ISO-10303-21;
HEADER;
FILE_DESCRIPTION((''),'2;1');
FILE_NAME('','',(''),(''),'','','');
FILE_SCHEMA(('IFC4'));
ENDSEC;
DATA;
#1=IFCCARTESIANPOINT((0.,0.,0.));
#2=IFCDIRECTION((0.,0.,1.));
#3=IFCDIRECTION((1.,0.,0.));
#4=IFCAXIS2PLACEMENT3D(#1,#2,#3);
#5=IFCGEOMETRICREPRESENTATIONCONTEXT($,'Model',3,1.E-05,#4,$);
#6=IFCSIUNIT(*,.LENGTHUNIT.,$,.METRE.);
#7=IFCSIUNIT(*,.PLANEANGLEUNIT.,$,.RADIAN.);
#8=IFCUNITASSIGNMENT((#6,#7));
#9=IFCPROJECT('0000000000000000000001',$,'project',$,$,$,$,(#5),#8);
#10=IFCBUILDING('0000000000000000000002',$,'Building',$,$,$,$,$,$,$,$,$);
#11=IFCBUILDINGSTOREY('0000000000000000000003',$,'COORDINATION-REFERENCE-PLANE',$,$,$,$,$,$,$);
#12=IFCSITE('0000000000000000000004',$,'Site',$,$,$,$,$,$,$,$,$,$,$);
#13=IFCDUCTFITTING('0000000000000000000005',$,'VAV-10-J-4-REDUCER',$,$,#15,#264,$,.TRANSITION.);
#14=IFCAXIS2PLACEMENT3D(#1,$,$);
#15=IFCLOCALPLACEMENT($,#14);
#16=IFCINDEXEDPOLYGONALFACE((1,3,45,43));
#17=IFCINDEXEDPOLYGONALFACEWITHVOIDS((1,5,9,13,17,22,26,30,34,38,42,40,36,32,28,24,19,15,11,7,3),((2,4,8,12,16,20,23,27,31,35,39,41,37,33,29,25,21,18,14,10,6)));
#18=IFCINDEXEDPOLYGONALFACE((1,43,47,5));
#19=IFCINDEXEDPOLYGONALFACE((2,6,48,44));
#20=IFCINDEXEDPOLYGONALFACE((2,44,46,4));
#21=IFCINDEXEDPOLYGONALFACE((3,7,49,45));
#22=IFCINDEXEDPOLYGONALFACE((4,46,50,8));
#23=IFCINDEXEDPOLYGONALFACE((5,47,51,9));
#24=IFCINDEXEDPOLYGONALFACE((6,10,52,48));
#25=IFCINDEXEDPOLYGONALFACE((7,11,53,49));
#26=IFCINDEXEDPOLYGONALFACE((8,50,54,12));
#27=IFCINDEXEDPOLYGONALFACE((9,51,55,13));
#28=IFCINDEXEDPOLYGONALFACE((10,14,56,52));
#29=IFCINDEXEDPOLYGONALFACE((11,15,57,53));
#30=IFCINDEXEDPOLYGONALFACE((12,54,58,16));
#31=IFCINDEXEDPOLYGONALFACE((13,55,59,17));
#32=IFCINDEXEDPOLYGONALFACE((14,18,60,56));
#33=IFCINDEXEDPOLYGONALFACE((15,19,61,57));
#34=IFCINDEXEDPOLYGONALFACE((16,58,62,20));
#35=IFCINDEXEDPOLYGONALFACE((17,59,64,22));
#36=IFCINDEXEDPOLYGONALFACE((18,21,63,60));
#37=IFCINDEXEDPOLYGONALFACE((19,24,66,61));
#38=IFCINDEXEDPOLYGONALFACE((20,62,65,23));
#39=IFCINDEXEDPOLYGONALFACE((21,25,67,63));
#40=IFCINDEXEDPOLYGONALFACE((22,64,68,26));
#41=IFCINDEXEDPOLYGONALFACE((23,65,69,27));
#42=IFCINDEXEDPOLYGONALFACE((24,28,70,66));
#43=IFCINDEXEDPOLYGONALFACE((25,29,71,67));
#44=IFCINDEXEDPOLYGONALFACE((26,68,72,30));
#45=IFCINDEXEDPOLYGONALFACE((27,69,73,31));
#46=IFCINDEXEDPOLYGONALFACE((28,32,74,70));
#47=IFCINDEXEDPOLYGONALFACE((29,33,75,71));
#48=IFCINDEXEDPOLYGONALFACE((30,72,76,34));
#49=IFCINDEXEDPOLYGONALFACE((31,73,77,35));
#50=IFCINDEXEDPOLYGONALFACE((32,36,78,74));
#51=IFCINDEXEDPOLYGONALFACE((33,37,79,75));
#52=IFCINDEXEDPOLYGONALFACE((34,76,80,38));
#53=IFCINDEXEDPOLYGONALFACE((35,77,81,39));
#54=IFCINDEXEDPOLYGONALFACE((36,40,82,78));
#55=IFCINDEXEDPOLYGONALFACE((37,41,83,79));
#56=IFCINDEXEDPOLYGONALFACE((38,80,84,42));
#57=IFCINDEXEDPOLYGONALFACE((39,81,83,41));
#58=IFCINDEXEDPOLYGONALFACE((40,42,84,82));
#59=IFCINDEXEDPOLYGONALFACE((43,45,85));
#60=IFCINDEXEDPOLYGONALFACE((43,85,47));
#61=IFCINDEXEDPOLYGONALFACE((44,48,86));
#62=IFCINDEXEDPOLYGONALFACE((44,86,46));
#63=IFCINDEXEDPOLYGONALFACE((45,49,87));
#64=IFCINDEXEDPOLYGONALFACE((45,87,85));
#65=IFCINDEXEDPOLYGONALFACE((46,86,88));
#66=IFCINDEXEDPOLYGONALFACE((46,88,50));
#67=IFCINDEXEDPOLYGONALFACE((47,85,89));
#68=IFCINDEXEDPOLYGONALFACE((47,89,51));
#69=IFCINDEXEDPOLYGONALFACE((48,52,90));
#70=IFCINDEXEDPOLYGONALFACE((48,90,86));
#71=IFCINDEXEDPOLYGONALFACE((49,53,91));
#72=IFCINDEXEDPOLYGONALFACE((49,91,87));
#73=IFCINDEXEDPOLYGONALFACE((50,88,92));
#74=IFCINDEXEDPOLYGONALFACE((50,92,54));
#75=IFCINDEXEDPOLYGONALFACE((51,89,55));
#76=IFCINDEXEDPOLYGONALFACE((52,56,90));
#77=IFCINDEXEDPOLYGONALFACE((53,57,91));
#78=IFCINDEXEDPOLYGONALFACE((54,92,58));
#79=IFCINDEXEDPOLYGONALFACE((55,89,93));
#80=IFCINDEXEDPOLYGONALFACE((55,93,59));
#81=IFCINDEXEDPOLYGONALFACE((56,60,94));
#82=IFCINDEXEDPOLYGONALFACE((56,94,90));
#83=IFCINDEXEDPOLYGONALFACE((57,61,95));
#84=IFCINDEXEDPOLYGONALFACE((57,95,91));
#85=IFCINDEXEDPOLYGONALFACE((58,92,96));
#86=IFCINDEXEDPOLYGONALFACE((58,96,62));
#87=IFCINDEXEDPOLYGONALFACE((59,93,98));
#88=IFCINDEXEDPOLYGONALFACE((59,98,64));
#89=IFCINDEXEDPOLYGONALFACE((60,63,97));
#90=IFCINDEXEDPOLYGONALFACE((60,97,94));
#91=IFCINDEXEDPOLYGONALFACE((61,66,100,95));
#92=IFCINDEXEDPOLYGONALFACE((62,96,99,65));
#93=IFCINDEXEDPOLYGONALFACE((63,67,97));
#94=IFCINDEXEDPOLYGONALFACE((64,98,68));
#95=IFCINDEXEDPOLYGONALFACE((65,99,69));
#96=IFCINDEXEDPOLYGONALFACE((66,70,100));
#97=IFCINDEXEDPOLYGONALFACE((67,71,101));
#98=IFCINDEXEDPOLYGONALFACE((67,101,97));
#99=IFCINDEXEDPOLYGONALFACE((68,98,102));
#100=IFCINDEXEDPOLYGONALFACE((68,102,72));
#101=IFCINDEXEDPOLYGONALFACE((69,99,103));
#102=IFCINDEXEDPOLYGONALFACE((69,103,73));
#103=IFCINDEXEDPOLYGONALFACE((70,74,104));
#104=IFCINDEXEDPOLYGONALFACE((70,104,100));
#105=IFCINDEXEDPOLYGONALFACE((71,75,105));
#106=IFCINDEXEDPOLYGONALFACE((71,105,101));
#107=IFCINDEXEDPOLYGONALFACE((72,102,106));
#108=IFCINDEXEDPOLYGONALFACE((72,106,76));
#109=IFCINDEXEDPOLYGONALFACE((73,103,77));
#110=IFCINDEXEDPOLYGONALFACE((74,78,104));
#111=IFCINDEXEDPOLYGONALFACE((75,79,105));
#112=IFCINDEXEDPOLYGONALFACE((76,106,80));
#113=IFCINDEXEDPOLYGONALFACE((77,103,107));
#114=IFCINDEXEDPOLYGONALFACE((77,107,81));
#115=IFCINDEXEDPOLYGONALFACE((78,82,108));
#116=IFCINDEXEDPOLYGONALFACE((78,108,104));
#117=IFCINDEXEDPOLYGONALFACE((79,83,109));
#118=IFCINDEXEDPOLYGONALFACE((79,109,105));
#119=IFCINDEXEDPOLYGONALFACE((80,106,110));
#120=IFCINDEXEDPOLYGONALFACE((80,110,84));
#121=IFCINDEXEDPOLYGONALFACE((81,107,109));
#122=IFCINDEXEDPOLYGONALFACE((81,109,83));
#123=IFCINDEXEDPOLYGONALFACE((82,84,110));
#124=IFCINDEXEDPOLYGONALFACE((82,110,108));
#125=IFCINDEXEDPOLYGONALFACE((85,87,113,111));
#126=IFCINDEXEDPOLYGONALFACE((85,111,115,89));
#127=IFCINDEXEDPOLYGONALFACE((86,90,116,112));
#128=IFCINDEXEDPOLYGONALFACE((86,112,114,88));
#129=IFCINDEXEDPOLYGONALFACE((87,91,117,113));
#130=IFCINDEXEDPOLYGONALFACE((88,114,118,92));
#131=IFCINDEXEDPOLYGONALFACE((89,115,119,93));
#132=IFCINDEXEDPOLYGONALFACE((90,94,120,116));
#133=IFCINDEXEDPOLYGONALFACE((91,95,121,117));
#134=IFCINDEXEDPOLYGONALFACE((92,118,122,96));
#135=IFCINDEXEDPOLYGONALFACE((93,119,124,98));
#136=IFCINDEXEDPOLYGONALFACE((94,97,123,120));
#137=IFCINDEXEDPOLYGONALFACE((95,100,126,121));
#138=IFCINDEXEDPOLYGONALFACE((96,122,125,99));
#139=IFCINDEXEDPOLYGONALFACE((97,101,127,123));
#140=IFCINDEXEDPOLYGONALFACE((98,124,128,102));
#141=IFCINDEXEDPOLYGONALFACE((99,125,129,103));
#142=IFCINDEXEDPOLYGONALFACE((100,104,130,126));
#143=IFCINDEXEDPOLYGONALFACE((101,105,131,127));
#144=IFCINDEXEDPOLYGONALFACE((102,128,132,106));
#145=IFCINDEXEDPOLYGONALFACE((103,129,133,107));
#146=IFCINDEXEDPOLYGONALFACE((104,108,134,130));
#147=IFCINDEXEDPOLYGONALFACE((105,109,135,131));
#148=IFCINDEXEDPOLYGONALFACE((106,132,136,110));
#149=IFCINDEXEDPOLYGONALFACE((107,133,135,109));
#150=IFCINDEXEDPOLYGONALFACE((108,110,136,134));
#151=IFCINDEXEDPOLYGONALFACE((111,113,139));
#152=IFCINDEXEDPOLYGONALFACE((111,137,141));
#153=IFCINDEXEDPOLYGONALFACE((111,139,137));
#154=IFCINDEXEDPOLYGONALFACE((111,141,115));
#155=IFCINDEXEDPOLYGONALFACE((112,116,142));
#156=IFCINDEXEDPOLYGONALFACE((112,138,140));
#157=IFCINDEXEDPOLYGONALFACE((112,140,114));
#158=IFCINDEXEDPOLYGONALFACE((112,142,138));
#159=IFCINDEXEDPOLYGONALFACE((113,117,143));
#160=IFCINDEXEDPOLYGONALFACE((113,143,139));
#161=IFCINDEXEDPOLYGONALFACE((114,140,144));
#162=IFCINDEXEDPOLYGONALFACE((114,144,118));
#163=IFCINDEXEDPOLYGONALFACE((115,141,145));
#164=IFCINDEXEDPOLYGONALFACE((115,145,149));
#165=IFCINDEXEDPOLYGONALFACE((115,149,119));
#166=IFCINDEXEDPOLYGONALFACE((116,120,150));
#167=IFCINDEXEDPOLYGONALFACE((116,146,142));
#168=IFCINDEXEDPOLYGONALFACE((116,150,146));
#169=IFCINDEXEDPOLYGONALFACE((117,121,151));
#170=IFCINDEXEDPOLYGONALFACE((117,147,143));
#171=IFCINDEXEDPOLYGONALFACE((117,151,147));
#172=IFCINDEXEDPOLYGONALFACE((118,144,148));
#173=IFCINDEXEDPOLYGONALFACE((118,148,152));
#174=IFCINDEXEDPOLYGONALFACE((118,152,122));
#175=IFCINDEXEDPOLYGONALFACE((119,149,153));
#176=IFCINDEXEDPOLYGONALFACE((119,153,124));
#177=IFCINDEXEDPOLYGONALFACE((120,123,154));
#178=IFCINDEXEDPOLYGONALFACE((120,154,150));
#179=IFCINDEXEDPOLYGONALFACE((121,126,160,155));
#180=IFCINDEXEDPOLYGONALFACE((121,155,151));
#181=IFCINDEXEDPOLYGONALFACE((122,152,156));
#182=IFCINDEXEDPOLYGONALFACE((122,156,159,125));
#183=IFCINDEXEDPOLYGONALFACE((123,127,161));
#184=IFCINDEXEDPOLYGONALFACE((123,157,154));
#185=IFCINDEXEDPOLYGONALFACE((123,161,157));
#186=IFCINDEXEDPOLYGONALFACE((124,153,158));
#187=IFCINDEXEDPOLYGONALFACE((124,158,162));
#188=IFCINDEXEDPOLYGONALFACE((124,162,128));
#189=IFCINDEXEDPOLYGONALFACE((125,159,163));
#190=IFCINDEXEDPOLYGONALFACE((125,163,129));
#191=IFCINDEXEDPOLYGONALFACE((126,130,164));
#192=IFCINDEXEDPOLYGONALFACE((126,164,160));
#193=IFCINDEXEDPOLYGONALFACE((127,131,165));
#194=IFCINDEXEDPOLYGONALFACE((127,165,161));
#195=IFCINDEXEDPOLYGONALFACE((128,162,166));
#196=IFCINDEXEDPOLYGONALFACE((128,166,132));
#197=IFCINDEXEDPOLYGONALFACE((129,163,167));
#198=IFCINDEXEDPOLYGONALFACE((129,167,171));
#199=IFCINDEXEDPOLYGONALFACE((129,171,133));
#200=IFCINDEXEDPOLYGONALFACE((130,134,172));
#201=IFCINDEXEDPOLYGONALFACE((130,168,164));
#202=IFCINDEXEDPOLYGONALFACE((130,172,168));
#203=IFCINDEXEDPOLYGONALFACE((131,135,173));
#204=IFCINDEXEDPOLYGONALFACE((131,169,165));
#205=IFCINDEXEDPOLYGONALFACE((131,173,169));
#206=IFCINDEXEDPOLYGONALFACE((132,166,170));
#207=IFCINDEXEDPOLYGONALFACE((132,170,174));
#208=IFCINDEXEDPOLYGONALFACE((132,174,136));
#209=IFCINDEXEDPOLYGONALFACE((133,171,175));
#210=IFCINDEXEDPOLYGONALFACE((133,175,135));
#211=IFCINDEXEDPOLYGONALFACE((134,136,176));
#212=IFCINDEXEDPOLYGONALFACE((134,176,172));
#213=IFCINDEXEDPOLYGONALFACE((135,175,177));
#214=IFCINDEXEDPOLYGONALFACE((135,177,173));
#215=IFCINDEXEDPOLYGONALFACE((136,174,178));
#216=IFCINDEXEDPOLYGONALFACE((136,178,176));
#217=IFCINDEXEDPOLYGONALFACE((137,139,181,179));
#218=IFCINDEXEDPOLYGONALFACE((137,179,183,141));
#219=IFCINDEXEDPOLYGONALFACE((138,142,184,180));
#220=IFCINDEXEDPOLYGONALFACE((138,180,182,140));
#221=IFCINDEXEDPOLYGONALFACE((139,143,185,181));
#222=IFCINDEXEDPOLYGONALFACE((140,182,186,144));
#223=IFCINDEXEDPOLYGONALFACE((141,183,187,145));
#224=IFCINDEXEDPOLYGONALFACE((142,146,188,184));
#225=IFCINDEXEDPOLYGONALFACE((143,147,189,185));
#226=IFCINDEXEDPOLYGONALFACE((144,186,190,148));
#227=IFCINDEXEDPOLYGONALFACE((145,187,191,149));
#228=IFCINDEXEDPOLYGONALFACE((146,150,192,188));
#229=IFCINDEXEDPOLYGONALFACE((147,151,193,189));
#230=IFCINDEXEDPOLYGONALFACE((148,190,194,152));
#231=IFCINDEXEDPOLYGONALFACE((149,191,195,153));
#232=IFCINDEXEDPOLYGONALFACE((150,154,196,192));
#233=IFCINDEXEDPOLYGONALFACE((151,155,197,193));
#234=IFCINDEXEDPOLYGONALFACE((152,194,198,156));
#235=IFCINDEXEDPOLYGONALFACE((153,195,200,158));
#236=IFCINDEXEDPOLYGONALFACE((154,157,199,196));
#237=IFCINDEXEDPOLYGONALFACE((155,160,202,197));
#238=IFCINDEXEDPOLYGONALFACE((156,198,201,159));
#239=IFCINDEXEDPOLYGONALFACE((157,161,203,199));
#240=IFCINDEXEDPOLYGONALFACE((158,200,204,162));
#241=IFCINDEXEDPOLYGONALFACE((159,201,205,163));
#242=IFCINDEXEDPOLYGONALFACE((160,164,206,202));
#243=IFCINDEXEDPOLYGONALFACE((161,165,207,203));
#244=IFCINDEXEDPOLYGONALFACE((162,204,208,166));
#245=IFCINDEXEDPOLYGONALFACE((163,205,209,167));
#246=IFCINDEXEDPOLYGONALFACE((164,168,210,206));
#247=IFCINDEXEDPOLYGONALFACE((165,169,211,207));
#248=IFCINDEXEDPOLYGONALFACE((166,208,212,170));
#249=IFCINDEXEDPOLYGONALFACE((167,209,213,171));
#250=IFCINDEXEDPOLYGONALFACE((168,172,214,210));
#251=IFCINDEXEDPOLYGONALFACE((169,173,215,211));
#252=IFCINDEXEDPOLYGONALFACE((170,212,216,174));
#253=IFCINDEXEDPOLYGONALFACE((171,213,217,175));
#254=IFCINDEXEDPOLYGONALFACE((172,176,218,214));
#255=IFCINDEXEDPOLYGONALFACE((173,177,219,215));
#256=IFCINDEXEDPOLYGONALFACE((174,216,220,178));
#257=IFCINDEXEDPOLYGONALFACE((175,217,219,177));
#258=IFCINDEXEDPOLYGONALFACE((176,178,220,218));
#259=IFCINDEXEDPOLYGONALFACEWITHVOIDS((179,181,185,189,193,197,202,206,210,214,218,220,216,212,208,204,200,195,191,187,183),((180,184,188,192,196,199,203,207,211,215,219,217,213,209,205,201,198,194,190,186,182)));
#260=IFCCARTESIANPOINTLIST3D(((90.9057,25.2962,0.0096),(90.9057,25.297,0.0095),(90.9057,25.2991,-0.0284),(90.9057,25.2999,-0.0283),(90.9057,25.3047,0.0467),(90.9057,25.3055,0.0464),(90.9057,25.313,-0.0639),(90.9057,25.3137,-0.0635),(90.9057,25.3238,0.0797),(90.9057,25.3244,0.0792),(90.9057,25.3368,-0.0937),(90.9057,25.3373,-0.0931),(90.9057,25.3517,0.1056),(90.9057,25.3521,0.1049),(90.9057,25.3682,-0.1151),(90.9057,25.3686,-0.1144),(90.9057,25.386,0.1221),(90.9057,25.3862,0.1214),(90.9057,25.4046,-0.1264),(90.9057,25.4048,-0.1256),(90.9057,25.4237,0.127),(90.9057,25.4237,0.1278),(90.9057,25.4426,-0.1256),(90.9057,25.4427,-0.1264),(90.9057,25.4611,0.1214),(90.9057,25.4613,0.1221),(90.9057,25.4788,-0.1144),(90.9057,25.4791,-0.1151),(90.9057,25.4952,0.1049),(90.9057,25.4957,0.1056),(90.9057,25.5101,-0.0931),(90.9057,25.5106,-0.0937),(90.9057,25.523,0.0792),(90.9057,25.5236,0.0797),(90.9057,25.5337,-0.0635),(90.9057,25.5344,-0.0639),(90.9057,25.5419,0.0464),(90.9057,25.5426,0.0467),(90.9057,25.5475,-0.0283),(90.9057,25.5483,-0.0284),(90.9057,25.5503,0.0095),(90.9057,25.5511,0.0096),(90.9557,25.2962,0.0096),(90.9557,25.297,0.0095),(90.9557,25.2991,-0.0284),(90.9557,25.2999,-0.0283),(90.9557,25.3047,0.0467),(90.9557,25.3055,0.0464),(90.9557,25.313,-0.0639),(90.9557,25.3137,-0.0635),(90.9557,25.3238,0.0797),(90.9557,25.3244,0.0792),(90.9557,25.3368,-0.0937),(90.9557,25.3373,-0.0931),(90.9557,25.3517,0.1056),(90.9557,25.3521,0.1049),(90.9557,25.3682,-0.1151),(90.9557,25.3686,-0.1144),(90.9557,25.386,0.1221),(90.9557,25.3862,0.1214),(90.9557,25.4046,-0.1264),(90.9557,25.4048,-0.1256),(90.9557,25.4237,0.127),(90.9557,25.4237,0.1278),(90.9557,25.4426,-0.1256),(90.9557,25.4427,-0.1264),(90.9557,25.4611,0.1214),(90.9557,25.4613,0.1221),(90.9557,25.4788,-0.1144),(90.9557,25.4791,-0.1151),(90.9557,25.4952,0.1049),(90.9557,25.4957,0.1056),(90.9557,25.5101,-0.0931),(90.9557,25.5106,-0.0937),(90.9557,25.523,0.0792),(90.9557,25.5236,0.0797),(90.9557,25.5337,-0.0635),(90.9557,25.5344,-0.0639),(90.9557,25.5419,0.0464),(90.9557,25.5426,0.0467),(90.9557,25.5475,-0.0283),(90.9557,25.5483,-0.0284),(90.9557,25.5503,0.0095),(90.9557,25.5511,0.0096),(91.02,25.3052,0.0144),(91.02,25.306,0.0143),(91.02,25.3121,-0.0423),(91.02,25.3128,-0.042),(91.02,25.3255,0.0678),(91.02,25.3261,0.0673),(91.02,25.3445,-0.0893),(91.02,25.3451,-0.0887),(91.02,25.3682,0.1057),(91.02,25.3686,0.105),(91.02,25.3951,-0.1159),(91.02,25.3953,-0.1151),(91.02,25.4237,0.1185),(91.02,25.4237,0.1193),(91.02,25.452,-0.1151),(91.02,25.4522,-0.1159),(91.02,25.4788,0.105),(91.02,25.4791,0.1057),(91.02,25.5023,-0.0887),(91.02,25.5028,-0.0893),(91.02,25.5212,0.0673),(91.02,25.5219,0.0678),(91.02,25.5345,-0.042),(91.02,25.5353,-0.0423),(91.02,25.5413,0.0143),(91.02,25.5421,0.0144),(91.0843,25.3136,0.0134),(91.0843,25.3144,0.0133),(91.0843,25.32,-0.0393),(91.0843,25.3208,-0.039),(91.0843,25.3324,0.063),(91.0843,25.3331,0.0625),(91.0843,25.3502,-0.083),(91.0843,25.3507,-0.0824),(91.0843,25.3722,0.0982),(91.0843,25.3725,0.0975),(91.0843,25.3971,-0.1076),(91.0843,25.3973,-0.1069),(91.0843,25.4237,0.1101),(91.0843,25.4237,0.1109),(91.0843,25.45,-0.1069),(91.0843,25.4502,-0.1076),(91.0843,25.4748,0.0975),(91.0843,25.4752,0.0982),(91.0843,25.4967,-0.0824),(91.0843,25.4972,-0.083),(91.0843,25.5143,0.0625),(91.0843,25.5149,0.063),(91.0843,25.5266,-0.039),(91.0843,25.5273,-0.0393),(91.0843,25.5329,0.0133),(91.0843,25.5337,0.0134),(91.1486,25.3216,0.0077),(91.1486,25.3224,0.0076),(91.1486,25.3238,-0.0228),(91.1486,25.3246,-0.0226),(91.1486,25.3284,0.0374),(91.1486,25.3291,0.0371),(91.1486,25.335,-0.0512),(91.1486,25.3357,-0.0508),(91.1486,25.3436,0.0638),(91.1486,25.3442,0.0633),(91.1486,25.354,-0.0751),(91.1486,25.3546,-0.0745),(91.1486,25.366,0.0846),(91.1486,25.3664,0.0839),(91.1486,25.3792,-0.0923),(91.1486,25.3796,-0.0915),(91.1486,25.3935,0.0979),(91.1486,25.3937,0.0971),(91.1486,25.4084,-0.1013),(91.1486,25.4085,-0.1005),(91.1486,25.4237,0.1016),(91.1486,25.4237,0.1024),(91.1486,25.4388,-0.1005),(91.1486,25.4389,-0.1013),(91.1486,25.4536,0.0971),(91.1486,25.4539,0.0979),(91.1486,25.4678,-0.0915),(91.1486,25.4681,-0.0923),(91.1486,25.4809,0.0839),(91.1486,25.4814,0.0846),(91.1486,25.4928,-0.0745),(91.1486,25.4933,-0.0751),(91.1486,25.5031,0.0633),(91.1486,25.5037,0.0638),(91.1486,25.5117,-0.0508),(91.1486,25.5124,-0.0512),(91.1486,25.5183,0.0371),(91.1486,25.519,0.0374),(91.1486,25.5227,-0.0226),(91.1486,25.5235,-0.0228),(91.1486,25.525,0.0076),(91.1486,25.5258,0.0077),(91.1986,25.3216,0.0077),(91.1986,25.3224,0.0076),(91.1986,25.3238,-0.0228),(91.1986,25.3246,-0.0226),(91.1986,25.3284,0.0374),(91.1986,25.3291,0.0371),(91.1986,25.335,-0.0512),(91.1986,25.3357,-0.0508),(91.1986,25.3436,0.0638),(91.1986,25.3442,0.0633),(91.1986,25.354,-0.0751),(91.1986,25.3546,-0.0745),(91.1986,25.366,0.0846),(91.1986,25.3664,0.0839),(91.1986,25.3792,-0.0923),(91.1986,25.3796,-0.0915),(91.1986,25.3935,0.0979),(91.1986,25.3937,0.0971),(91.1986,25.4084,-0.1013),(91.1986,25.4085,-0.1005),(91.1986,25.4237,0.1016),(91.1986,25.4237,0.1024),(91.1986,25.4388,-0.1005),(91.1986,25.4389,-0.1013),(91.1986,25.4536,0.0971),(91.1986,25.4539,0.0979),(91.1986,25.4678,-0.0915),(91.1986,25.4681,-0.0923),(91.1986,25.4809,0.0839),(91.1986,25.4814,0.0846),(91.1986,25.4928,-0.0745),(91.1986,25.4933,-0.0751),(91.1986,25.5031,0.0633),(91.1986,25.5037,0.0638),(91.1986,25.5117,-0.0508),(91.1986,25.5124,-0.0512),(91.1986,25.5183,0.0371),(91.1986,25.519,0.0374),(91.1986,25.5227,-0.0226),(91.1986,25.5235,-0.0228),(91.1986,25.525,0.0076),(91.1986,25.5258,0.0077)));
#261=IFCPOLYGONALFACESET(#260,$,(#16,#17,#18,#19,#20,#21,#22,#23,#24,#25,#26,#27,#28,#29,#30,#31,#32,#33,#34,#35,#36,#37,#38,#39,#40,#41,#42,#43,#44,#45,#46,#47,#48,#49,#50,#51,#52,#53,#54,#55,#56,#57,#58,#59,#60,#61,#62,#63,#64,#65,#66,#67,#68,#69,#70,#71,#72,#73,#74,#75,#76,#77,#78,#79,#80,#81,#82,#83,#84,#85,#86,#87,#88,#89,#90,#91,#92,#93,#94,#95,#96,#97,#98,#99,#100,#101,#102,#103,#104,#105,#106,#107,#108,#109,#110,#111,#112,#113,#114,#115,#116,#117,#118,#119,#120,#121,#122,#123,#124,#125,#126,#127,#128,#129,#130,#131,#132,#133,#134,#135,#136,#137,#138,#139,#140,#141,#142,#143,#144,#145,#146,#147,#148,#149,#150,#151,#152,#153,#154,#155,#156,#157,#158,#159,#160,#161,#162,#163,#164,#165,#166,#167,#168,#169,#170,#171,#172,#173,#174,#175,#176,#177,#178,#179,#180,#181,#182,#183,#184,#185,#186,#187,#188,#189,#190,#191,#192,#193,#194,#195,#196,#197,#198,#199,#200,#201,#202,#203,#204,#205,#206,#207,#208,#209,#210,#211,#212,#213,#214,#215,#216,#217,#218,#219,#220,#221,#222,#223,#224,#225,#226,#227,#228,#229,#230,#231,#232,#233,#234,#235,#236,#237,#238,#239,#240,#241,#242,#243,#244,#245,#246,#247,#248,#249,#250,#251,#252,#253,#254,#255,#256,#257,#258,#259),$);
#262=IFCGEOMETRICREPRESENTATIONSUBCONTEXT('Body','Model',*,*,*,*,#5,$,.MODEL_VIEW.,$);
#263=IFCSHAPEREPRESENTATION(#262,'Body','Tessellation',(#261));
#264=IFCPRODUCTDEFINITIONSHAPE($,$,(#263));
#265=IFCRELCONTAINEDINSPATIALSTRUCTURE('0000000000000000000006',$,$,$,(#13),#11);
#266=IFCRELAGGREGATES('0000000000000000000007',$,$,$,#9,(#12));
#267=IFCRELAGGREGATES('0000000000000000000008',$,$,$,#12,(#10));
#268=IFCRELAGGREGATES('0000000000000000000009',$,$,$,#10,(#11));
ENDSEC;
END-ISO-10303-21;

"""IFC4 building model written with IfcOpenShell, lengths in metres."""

from ifc_helpers import new_model, entity, si_unit, frame, origin_with_axes, place, context, subcontext, project, spatial, element, save


model = new_model("IFC4")

# Units and contexts
model_context_1 = context("Model", 3, precision=1e-05, world=origin_with_axes())
body_context_1 = subcontext(model_context_1, "Body", "Model", "MODEL_VIEW")
ifc_project = project(units=[si_unit("LENGTHUNIT", "METRE"), si_unit("PLANEANGLEUNIT", "RADIAN")], contexts=[model_context_1])

# Site, building, storey
site = spatial("IfcSite", under=ifc_project, Name="Site")
building = spatial("IfcBuilding", under=site, Name="Building")
storey = spatial("IfcBuildingStorey", under=building, Name="COORDINATION-REFERENCE-PLANE")

# Duct fitting
for number, where, z_axis, x_axis, name in (
    (1, (90.9057, 25.4237, 0.0), (0.0, 1.0, 0.0), (0.0, 0.0, 1.0), "VAV-10-J-4-REDUCER"),
):
    element("IfcDuctFitting", number, at=place(None, frame(where, z_axis=z_axis, x_axis=x_axis)), inside=storey, Name=name, PredefinedType="TRANSITION", context=body_context_1, shape_type="SweptSolid", body=[
        entity("IfcRevolvedAreaSolid", entity("IfcArbitraryClosedProfileDef", "AREA", None, entity("IfcPolyline", [entity("IfcCartesianPoint", [0.1278, 0.0]), entity("IfcCartesianPoint", [0.1278, 0.05]), entity("IfcCartesianPoint", [0.1024, 0.2429]), entity("IfcCartesianPoint", [0.1024, 0.2929]), entity("IfcCartesianPoint", [0.1016, 0.2929]), entity("IfcCartesianPoint", [0.1016, 0.2429]), entity("IfcCartesianPoint", [0.127, 0.05]), entity("IfcCartesianPoint", [0.127, 0.0]), entity("IfcCartesianPoint", [0.1278, 0.0])])), entity("IfcAxis2Placement3D", entity("IfcCartesianPoint", [0.0, 0.0, 0.0])), entity("IfcAxis1Placement", entity("IfcCartesianPoint", [0.0, 0.0, 0.0]), entity("IfcDirection", [0.0, 1.0, 0.0])), 6.283185),
    ])

save(model, "model.ifc")
